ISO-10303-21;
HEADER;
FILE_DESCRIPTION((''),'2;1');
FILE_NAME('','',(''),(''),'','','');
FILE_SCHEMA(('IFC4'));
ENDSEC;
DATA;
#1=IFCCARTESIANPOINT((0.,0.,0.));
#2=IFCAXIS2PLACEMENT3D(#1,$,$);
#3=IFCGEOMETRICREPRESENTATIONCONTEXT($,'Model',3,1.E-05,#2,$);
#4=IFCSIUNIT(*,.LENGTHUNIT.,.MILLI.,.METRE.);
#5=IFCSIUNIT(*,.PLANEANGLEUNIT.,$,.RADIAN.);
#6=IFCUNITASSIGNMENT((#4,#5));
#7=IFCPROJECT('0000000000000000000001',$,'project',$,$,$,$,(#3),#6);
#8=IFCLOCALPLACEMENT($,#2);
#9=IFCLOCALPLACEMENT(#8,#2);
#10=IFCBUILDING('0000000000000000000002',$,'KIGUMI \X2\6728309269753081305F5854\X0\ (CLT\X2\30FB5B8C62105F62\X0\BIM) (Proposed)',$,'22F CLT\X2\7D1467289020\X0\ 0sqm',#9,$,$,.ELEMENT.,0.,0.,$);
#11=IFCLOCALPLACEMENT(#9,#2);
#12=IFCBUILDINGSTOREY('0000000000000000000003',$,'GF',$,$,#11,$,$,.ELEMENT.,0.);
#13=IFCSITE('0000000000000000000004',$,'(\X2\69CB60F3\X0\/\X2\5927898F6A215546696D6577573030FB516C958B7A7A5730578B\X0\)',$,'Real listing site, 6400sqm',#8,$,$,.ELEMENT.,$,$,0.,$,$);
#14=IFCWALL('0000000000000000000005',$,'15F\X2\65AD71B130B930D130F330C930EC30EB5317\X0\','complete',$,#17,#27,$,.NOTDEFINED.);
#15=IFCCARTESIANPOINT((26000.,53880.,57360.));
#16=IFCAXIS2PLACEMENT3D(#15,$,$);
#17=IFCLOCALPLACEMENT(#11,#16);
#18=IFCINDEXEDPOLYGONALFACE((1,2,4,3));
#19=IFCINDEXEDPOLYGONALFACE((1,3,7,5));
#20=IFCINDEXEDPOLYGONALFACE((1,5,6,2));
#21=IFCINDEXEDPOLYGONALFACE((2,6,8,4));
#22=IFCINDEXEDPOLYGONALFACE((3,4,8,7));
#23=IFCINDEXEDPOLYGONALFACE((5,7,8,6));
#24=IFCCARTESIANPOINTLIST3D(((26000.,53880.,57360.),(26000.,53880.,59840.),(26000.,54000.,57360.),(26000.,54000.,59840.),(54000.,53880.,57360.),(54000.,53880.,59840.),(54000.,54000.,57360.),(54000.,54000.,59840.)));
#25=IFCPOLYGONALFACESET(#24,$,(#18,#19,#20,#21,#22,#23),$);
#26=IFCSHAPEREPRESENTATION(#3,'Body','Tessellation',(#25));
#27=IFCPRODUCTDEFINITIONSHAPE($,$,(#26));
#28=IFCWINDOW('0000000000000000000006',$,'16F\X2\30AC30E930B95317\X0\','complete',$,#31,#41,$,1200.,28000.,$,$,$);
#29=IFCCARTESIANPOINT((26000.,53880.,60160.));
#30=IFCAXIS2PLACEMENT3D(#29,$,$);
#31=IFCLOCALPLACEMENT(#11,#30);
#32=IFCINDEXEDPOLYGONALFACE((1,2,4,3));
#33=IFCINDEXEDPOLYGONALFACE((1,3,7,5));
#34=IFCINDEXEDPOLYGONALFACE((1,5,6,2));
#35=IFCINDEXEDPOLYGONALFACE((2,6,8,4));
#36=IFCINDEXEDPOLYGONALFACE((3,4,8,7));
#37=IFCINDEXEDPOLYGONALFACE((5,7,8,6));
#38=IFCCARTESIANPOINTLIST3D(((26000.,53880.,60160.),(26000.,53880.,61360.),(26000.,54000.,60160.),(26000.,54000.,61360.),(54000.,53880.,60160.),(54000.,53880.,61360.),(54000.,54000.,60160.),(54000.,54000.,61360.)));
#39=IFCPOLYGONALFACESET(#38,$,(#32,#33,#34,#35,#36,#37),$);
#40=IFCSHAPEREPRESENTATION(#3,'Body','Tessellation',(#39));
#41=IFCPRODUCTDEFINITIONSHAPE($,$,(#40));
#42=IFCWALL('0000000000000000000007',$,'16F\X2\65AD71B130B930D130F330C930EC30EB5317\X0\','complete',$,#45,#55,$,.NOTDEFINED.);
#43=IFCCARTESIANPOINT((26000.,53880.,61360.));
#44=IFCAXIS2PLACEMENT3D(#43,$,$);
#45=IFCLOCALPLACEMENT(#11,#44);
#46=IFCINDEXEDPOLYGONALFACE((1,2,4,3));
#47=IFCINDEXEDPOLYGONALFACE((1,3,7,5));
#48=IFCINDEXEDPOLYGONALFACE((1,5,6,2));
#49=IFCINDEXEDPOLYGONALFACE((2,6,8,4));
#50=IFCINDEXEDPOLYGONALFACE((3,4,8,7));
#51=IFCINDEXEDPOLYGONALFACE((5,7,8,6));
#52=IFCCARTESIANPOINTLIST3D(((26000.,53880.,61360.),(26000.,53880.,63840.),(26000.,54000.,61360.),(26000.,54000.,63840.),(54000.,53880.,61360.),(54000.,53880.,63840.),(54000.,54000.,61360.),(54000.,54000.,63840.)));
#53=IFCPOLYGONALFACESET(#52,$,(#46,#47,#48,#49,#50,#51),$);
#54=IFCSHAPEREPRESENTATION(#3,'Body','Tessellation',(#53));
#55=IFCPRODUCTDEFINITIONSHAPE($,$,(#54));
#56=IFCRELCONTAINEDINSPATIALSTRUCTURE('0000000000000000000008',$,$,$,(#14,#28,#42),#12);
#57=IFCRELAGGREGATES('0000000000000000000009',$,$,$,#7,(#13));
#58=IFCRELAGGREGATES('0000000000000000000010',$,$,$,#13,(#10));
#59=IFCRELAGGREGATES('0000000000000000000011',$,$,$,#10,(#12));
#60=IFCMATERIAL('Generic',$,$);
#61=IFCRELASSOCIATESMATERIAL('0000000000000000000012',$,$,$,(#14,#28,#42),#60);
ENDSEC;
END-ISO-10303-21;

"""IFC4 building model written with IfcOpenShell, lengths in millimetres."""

from ifc_helpers import new_model, si_unit, frame, frame_2d, origin, place, context, project, spatial, rectangle, extrude, material, element, save


model = new_model("IFC4")

# Units and contexts
model_context = context("Model", 3, precision=1e-05, world=origin())
ifc_project = project(units=[si_unit("LENGTHUNIT", "METRE", prefix="MILLI"), si_unit("PLANEANGLEUNIT", "RADIAN")], contexts=[model_context])

# Site, building, storey
site_placement = place(None, origin())
site = spatial("IfcSite", under=ifc_project, at=site_placement, Name="(構想/大規模商業敷地・公開空地型)", ObjectType="Real listing site, 6400sqm", CompositionType="ELEMENT", RefElevation=0.0)
building_placement = place(site_placement, origin())
building = spatial("IfcBuilding", under=site, at=building_placement, Name="KIGUMI 木を極めた塔 (CLT・完成形BIM) (Proposed)", ObjectType="22F CLT純木造 0sqm", CompositionType="ELEMENT", ElevationOfRefHeight=0.0, ElevationOfTerrain=0.0)
storey_placement = place(building_placement, origin())
storey = spatial("IfcBuildingStorey", under=building, at=storey_placement, Name="GF", CompositionType="ELEMENT", Elevation=0.0)

# Shared definitions
ifc_material = material(Name="Generic")

# Wall
wall_1_placement = place(storey_placement, frame((26000.0, 53880.0, 57360.0)))
element("IfcWall", 1, at=wall_1_placement, inside=storey, material=ifc_material, Name="15F断熱スパンドレル北", Description="complete", PredefinedType="NOTDEFINED", context=model_context, shape_type="SweptSolid", body=[
    extrude(rectangle(XDim=28000.0, YDim=120.0, at=frame_2d((14000.0, 60.0))), frame((26000.0, 53880.0, 57360.0)), (0.0, 0.0, 1.0), 2480.0),
])

# Window
window_1_placement = place(storey_placement, frame((26000.0, 53880.0, 60160.0)))
element("IfcWindow", 2, at=window_1_placement, inside=storey, material=ifc_material, Name="16Fガラス北", Description="complete", OverallHeight=1200.0, OverallWidth=28000.0, context=model_context, shape_type="SweptSolid", body=[
    extrude(rectangle(XDim=28000.0, YDim=120.0, at=frame_2d((14000.0, 60.0))), frame((26000.0, 53880.0, 60160.0)), (0.0, 0.0, 1.0), 1200.0),
])

# Wall
wall_2_placement = place(storey_placement, frame((26000.0, 53880.0, 61360.0)))
element("IfcWall", 3, at=wall_2_placement, inside=storey, material=ifc_material, Name="16F断熱スパンドレル北", Description="complete", PredefinedType="NOTDEFINED", context=model_context, shape_type="SweptSolid", body=[
    extrude(rectangle(XDim=28000.0, YDim=120.0, at=frame_2d((14000.0, 60.0))), frame((26000.0, 53880.0, 61360.0)), (0.0, 0.0, 1.0), 2480.0),
])

save(model, "model.ifc")
